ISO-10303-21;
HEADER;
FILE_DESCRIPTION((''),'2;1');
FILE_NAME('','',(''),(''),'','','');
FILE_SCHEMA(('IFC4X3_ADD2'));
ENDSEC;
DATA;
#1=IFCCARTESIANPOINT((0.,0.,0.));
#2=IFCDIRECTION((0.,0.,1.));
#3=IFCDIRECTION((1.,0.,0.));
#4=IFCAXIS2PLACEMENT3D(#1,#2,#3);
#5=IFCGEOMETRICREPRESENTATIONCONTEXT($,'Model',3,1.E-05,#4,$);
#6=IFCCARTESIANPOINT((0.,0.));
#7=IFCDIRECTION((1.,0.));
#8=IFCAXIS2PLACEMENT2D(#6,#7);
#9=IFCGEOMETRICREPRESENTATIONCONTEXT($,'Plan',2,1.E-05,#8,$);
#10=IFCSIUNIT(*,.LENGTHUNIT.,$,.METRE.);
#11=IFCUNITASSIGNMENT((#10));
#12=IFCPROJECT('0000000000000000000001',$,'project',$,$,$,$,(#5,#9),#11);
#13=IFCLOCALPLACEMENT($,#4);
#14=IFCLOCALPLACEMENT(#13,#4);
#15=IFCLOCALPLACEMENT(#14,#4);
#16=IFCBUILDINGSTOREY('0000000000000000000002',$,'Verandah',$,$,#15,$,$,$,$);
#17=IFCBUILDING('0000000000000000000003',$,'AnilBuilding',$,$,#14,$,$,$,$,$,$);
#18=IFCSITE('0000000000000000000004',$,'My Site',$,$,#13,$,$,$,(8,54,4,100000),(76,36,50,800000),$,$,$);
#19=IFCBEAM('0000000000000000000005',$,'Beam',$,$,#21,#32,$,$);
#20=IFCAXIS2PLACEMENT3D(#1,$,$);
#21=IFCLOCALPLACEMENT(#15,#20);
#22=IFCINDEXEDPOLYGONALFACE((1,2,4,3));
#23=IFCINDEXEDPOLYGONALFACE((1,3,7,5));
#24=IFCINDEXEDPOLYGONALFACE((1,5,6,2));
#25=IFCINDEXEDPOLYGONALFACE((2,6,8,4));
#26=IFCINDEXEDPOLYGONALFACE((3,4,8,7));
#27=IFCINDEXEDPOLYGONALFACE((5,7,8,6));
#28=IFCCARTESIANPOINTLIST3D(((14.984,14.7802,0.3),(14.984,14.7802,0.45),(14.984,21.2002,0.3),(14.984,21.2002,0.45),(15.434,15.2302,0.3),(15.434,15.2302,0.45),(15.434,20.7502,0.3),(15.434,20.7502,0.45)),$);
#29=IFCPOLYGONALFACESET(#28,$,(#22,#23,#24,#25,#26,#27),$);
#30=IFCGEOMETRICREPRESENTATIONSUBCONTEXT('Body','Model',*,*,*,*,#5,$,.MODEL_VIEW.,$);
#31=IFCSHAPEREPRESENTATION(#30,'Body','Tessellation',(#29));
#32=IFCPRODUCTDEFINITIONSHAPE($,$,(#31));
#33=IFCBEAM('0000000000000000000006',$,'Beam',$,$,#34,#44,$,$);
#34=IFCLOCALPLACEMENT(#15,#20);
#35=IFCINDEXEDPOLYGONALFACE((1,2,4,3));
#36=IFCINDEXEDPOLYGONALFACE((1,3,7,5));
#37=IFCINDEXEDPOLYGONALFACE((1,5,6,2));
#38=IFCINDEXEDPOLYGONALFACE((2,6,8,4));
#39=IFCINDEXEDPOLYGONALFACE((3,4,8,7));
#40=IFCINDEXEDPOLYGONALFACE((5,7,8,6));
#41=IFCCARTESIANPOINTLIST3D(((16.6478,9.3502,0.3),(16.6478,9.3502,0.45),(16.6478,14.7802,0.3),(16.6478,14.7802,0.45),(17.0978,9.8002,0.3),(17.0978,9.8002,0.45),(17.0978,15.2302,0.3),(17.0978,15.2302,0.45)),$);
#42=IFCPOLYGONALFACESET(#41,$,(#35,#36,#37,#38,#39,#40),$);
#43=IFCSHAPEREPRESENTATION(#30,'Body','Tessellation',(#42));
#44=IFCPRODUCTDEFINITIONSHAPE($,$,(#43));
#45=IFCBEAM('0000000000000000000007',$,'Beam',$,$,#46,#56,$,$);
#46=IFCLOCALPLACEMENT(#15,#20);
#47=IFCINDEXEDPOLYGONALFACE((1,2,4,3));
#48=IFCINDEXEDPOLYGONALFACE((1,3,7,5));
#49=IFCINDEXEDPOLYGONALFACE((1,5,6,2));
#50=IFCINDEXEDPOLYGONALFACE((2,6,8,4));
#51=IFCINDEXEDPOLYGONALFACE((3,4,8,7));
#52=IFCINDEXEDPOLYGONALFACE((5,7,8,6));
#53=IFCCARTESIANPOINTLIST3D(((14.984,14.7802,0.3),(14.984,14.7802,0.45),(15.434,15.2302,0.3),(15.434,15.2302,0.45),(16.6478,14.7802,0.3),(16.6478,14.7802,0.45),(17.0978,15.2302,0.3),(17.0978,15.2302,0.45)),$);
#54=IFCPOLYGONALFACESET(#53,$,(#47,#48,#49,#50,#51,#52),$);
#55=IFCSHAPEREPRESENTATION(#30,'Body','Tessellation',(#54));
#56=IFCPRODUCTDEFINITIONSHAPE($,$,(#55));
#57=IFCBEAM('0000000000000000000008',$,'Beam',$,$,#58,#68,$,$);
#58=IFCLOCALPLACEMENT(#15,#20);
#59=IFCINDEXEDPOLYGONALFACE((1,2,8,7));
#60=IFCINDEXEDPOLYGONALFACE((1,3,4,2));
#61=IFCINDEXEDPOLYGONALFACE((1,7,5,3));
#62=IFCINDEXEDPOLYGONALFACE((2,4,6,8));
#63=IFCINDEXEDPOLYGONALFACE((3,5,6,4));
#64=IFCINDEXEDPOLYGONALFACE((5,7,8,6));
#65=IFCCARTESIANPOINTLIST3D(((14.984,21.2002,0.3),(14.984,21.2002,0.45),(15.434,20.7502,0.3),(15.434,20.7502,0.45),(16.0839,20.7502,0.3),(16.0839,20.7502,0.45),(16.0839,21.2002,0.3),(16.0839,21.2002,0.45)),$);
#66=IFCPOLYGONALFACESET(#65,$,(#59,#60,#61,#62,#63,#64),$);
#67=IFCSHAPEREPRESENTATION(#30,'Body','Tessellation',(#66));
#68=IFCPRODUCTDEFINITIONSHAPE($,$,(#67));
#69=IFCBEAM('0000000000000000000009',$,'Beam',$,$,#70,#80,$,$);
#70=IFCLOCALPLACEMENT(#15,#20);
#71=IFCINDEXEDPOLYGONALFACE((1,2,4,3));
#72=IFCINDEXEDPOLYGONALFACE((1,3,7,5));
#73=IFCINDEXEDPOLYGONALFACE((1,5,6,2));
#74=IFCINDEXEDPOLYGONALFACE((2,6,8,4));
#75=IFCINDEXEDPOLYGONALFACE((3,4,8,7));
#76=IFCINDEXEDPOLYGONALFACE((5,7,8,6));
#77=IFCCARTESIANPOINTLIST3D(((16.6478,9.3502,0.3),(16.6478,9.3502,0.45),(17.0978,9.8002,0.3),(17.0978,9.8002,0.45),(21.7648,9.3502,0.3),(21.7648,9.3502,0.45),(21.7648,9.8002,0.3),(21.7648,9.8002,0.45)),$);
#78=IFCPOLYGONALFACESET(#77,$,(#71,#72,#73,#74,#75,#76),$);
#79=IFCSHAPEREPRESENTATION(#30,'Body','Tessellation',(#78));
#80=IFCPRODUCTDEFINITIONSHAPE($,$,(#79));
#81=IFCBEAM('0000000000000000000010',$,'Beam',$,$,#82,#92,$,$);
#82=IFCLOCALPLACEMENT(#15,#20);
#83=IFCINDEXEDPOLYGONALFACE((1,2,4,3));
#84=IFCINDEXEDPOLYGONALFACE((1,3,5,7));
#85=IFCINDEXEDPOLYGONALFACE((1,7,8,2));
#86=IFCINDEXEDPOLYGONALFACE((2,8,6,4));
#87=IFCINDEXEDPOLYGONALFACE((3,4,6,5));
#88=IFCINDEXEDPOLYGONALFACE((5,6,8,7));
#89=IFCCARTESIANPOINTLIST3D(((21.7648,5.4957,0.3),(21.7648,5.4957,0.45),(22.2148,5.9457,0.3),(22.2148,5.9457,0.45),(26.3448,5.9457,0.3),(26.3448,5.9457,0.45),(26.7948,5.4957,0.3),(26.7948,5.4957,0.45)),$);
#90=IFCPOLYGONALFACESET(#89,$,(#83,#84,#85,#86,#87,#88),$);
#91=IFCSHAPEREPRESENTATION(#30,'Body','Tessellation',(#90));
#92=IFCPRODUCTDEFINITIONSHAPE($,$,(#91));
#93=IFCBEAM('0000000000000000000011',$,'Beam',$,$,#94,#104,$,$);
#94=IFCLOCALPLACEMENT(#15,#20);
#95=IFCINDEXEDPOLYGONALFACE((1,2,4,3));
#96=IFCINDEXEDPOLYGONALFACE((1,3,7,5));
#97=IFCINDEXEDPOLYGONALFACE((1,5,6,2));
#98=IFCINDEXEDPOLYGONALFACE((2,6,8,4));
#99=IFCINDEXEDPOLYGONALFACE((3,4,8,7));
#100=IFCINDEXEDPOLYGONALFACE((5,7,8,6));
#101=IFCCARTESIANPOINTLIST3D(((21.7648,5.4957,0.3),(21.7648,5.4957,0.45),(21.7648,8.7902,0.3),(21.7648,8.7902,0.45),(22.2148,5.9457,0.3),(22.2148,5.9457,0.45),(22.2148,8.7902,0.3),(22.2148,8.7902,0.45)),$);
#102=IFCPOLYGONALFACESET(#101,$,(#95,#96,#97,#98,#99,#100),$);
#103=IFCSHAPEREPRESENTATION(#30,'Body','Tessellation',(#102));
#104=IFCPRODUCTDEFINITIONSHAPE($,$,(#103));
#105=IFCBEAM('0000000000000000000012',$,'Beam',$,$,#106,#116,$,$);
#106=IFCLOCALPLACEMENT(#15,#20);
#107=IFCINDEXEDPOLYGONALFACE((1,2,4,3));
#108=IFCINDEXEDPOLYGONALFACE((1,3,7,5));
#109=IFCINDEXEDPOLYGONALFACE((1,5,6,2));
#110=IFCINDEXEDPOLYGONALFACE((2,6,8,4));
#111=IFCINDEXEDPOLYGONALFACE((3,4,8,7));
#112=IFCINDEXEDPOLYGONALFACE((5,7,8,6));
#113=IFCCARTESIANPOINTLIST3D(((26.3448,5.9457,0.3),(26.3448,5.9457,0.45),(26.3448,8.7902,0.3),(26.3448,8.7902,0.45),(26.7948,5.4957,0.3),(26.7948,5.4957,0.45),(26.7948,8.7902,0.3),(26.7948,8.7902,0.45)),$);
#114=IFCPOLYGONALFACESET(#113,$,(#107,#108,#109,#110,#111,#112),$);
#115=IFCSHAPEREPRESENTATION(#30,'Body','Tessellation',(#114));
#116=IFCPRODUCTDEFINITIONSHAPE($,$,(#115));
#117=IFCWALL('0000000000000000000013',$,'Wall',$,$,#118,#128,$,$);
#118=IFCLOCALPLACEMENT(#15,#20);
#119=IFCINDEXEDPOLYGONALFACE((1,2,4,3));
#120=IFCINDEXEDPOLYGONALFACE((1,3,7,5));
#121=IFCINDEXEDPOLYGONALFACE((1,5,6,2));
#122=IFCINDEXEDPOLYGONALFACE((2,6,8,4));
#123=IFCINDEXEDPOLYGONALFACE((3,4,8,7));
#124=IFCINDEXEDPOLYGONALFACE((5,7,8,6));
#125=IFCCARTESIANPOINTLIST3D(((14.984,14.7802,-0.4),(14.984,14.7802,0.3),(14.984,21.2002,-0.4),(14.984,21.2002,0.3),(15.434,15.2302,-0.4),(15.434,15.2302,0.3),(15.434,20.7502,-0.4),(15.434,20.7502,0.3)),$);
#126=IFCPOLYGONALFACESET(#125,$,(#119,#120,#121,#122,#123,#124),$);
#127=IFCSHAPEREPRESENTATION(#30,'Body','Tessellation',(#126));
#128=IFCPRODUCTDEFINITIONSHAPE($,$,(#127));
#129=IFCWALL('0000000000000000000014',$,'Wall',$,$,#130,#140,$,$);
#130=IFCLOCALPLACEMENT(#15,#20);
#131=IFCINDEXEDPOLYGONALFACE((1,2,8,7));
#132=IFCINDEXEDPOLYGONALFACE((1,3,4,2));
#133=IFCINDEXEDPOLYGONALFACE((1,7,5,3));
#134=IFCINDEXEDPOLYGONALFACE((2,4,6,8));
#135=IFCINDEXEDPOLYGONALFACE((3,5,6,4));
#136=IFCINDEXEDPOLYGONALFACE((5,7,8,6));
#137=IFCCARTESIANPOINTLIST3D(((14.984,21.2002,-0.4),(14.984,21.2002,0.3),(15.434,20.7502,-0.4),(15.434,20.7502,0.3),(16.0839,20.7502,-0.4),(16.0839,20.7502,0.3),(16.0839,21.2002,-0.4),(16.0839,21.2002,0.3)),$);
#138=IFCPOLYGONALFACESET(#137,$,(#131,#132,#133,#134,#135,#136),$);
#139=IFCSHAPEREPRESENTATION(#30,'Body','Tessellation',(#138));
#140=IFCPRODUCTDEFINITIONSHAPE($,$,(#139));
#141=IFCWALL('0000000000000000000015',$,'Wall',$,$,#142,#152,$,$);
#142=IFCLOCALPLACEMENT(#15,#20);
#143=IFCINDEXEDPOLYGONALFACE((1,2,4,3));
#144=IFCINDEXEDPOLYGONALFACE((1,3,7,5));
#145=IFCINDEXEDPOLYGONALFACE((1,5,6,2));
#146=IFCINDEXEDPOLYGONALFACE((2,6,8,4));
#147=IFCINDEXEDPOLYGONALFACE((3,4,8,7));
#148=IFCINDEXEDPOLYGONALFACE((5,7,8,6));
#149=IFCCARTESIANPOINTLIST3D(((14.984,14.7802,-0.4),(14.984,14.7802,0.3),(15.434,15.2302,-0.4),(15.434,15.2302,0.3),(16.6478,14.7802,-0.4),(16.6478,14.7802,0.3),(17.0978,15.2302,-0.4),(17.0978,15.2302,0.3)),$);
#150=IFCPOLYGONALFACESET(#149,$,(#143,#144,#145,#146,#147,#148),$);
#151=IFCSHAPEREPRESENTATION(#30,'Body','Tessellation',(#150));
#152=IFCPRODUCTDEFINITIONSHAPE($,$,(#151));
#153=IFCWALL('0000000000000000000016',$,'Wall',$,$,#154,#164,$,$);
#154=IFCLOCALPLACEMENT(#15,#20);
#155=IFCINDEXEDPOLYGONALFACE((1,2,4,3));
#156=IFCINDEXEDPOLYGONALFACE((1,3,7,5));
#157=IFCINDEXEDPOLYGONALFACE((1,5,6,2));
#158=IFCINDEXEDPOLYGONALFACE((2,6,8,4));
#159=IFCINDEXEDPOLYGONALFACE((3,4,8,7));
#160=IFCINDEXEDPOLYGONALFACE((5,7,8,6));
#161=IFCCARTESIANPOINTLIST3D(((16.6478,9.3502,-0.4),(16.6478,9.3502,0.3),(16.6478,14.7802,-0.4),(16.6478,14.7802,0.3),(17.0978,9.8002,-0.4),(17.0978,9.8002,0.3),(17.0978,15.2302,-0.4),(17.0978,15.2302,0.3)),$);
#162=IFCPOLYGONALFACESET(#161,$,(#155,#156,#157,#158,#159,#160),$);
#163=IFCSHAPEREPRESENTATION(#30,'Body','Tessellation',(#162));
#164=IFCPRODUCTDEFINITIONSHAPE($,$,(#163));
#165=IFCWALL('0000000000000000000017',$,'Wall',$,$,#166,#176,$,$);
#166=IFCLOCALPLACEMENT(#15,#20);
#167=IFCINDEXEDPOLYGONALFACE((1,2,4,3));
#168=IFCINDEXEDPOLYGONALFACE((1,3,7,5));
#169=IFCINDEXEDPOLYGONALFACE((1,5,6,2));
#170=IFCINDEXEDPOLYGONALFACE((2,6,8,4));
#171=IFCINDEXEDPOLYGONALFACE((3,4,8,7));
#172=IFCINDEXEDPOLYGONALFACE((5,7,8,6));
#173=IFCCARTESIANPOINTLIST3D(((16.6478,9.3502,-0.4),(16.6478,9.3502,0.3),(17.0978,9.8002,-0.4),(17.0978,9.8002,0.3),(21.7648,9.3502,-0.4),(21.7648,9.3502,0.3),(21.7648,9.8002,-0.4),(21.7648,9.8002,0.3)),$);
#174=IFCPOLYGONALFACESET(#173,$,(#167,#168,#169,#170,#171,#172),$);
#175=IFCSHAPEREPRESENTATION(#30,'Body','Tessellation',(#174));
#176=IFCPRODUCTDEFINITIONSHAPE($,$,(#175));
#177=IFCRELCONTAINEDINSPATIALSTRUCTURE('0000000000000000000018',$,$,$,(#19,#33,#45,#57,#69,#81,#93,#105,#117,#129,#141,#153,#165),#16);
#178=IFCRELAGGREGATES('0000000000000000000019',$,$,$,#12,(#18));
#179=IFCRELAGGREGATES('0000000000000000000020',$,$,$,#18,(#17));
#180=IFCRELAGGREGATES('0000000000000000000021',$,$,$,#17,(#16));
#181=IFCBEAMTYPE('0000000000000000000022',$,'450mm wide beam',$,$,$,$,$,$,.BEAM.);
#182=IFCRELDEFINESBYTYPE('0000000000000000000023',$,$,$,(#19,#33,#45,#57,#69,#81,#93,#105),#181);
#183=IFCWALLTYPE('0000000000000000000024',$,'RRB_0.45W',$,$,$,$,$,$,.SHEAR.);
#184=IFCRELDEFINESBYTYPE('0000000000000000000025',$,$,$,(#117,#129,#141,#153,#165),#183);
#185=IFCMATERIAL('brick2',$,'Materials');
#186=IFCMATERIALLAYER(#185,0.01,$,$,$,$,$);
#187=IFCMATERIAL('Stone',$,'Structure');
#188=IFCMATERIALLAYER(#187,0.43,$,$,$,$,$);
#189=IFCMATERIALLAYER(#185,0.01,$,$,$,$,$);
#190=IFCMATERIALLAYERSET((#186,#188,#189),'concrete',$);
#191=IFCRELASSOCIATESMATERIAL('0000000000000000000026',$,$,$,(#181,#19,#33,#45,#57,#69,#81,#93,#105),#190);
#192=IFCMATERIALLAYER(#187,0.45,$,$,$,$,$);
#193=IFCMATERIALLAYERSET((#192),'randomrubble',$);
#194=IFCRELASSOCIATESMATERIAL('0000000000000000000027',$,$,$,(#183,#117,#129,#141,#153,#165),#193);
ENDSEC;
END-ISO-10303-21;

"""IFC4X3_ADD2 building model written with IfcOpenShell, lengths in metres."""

from ifc_helpers import new_model, si_unit, frame, origin_with_axes, origin_2d_with_axis, place, context, subcontext, project, spatial, line, indexed_curve, outline, extrude, material, layer, layer_set, layer_usage, type_object, element, save


model = new_model("IFC4X3_ADD2")

# Units and contexts
model_context = context("Model", 3, precision=1e-05, world=origin_with_axes())
plan_context = context("Plan", 2, precision=1e-05, world=origin_2d_with_axis())
body_context = subcontext(model_context, "Body", "Model", "MODEL_VIEW")
ifc_project = project(units=[si_unit("LENGTHUNIT", "METRE")], contexts=[model_context, plan_context])

# Site, building, storey
site_placement = place(None, origin_with_axes())
site = spatial("IfcSite", under=ifc_project, at=site_placement, Name="My Site", RefLatitude=(8, 54, 4, 100000), RefLongitude=(76, 36, 50, 800000))
building_placement = place(site_placement, origin_with_axes())
building = spatial("IfcBuilding", under=site, at=building_placement, Name="AnilBuilding")
storey_placement = place(building_placement, origin_with_axes())
storey = spatial("IfcBuildingStorey", under=building, at=storey_placement, Name="Verandah")

# Beams
ifc_material_1 = material(Name="brick2", Category="Materials")
ifc_layer_1 = layer(ifc_material_1, 0.01)
ifc_material_2 = material(Name="Stone", Category="Structure")
ifc_layer_2 = layer(ifc_material_2, 0.43)
ifc_layer_3 = layer(ifc_material_1, 0.01)
ifc_layer_set_1 = layer_set([ifc_layer_1, ifc_layer_2, ifc_layer_3], Name="concrete")
ifc_layer_usage_1 = layer_usage(ifc_layer_set_1, "AXIS2", "POSITIVE", 0.0)
beam_type = type_object("IfcBeamType", Name="450mm wide beam", PredefinedType="BEAM", material=ifc_layer_set_1)
beam_1_placement = place(storey_placement, frame((14.984, 21.2002, 0.3), z_axis=(0.0, 0.0, 1.0), x_axis=(0.0, -1.0, 0.0)))
element("IfcBeam", 1, at=beam_1_placement, inside=storey, type_object=beam_type, material=ifc_layer_usage_1, Name="Beam", context=body_context, shape_type="SweptSolid", body=[
    extrude(outline(indexed_curve([(0.0, 0.0), (0.45, 0.45), (5.97, 0.45), (6.42, 0.0)], segments=[line(1, 2, 3, 4, 1)])), origin_with_axes(), (0.0, 0.0, 1.0), 0.15),
])
ifc_layer_usage_2 = layer_usage(ifc_layer_set_1, "AXIS2", "POSITIVE", 0.0)
beam_2_placement = place(storey_placement, frame((16.6478, 15.2302, 0.3), z_axis=(0.0, 0.0, 1.0), x_axis=(0.0, -1.0, 0.0)))
element("IfcBeam", 2, at=beam_2_placement, inside=storey, type_object=beam_type, material=ifc_layer_usage_2, Name="Beam", context=body_context, shape_type="SweptSolid", body=[
    extrude(outline(indexed_curve([(0.45, 0.0), (0.0, 0.45), (5.43, 0.45), (5.88, 0.0)], segments=[line(1, 2, 3, 4, 1)])), origin_with_axes(), (0.0, 0.0, 1.0), 0.15),
])
ifc_layer_usage_3 = layer_usage(ifc_layer_set_1, "AXIS2", "NEGATIVE", 0.0)
beam_3_placement = place(storey_placement, frame((14.984, 15.2302, 0.3), z_axis=(0.0, 0.0, 1.0), x_axis=(1.0, 0.0, 0.0)))
element("IfcBeam", 3, at=beam_3_placement, inside=storey, type_object=beam_type, material=ifc_layer_usage_3, Name="Beam", context=body_context, shape_type="SweptSolid", body=[
    extrude(outline(indexed_curve([(0.0, -0.45), (0.45, 0.0), (2.1138, 0.0), (1.6638, -0.45)], segments=[line(1, 2, 3, 4, 1)])), origin_with_axes(), (0.0, 0.0, 1.0), 0.15),
])
ifc_layer_usage_4 = layer_usage(ifc_layer_set_1, "AXIS2", "NEGATIVE", 0.0)
beam_4_placement = place(storey_placement, frame((14.984, 21.2002, 0.3), z_axis=(0.0, 0.0, 1.0), x_axis=(1.0, 0.0, 0.0)))
element("IfcBeam", 4, at=beam_4_placement, inside=storey, type_object=beam_type, material=ifc_layer_usage_4, Name="Beam", context=body_context, shape_type="SweptSolid", body=[
    extrude(outline(indexed_curve([(0.45, -0.45), (0.0, 0.0), (1.1, 0.0), (1.1, -0.45)], segments=[line(1, 2, 3, 4, 1)])), origin_with_axes(), (0.0, 0.0, 1.0), 0.15),
])
ifc_layer_usage_5 = layer_usage(ifc_layer_set_1, "AXIS2", "NEGATIVE", 0.0)
beam_5_placement = place(storey_placement, frame((16.6478, 9.8002, 0.3), z_axis=(0.0, 0.0, 1.0), x_axis=(1.0, 0.0, 0.0)))
element("IfcBeam", 5, at=beam_5_placement, inside=storey, type_object=beam_type, material=ifc_layer_usage_5, Name="Beam", context=body_context, shape_type="SweptSolid", body=[
    extrude(outline(indexed_curve([(0.0, -0.45), (0.45, 0.0), (5.117, 0.0), (5.117, -0.45)], segments=[line(1, 2, 3, 4, 1)])), origin_with_axes(), (0.0, 0.0, 1.0), 0.15),
])
ifc_layer_usage_6 = layer_usage(ifc_layer_set_1, "AXIS2", "NEGATIVE", 0.0)
beam_6_placement = place(storey_placement, frame((21.7648, 5.9457, 0.3), z_axis=(0.0, 0.0, 1.0), x_axis=(1.0, 0.0, 0.0)))
element("IfcBeam", 6, at=beam_6_placement, inside=storey, type_object=beam_type, material=ifc_layer_usage_6, Name="Beam", context=body_context, shape_type="SweptSolid", body=[
    extrude(outline(indexed_curve([(0.0, -0.45), (0.45, 0.0), (4.58, 0.0), (5.03, -0.45)], segments=[line(1, 2, 3, 4, 1)])), origin_with_axes(), (0.0, 0.0, 1.0), 0.15),
])
ifc_layer_usage_7 = layer_usage(ifc_layer_set_1, "AXIS2", "POSITIVE", 0.0)
beam_7_placement = place(storey_placement, frame((21.7648, 8.7902, 0.3), z_axis=(0.0, 0.0, 1.0), x_axis=(0.0, -1.0, 0.0)))
element("IfcBeam", 7, at=beam_7_placement, inside=storey, type_object=beam_type, material=ifc_layer_usage_7, Name="Beam", context=body_context, shape_type="SweptSolid", body=[
    extrude(outline(indexed_curve([(0.0, 0.0), (0.0, 0.45), (2.8445, 0.45), (3.2945, 0.0)], segments=[line(1, 2, 3, 4, 1)])), origin_with_axes(), (0.0, 0.0, 1.0), 0.15),
])
ifc_layer_usage_8 = layer_usage(ifc_layer_set_1, "AXIS2", "POSITIVE", 0.0)
beam_8_placement = place(storey_placement, frame((26.3448, 8.7902, 0.3), z_axis=(0.0, 0.0, 1.0), x_axis=(0.0, -1.0, 0.0)))
element("IfcBeam", 8, at=beam_8_placement, inside=storey, type_object=beam_type, material=ifc_layer_usage_8, Name="Beam", context=body_context, shape_type="SweptSolid", body=[
    extrude(outline(indexed_curve([(0.0, 0.0), (0.0, 0.45), (3.2945, 0.45), (2.8445, 0.0)], segments=[line(1, 2, 3, 4, 1)])), origin_with_axes(), (0.0, 0.0, 1.0), 0.15),
])

# Walls
ifc_layer_4 = layer(ifc_material_2, 0.45)
ifc_layer_set_2 = layer_set([ifc_layer_4], Name="randomrubble")
ifc_layer_usage_9 = layer_usage(ifc_layer_set_2, "AXIS2", "POSITIVE", 0.0)
wall_type_1 = type_object("IfcWallType", Name="RRB_0.45W", PredefinedType="SHEAR", material=ifc_layer_set_2)
wall_1_placement = place(storey_placement, frame((15.434, 14.7802, -0.4), z_axis=(0.0, 0.0, 1.0), x_axis=(0.000001, 1.0, 0.0)))
element("IfcWall", 9, at=wall_1_placement, inside=storey, type_object=wall_type_1, material=ifc_layer_usage_9, Name="Wall", context=body_context, shape_type="SweptSolid", body=[
    extrude(outline(indexed_curve([(0.45, 0.0), (0.0, 0.45), (6.42, 0.45), (5.97, 0.0)], segments=[line(1, 2, 3, 4, 1)])), origin_with_axes(), (0.0, 0.0, 1.0), 0.7),
])
ifc_layer_usage_10 = layer_usage(ifc_layer_set_2, "AXIS2", "POSITIVE", 0.0)
wall_2_placement = place(storey_placement, frame((15.434, 20.7502, -0.4), z_axis=(0.0, 0.0, 1.0), x_axis=(1.0, 0.0, 0.0)))
element("IfcWall", 10, at=wall_2_placement, inside=storey, type_object=wall_type_1, material=ifc_layer_usage_10, Name="Wall", context=body_context, shape_type="SweptSolid", body=[
    extrude(outline(indexed_curve([(0.0, 0.0), (-0.45, 0.45), (0.6499, 0.45), (0.6499, 0.0)], segments=[line(1, 2, 3, 4, 1)])), origin_with_axes(), (0.0, 0.0, 1.0), 0.7),
])
ifc_layer_usage_11 = layer_usage(ifc_layer_set_2, "AXIS2", "POSITIVE", 0.0)
wall_3_placement = place(storey_placement, frame((15.434, 14.7802, -0.4), z_axis=(0.0, 0.0, 1.0), x_axis=(1.0, 0.0, 0.0)))
element("IfcWall", 11, at=wall_3_placement, inside=storey, type_object=wall_type_1, material=ifc_layer_usage_11, Name="Wall", context=body_context, shape_type="SweptSolid", body=[
    extrude(outline(indexed_curve([(-0.45, 0.0), (0.0, 0.45), (1.6638, 0.45), (1.2138, 0.0)], segments=[line(1, 2, 3, 4, 1)])), origin_with_axes(), (0.0, 0.0, 1.0), 0.7),
])
ifc_layer_usage_12 = layer_usage(ifc_layer_set_2, "AXIS2", "POSITIVE", 0.0)
wall_4_placement = place(storey_placement, frame((17.0978, 9.3502, -0.4), z_axis=(0.0, 0.0, 1.0), x_axis=(0.000001, 1.0, 0.0)))
element("IfcWall", 12, at=wall_4_placement, inside=storey, type_object=wall_type_1, material=ifc_layer_usage_12, Name="Wall", context=body_context, shape_type="SweptSolid", body=[
    extrude(outline(indexed_curve([(0.45, 0.0), (0.0, 0.45), (5.43, 0.45), (5.88, 0.0)], segments=[line(1, 2, 3, 4, 1)])), origin_with_axes(), (0.0, 0.0, 1.0), 0.7),
])
ifc_layer_usage_13 = layer_usage(ifc_layer_set_2, "AXIS2", "POSITIVE", 0.0)
wall_5_placement = place(storey_placement, frame((17.0978, 9.3502, -0.4), z_axis=(0.0, 0.0, 1.0), x_axis=(1.0, 0.0, 0.0)))
element("IfcWall", 13, at=wall_5_placement, inside=storey, type_object=wall_type_1, material=ifc_layer_usage_13, Name="Wall", context=body_context, shape_type="SweptSolid", body=[
    extrude(outline(indexed_curve([(-0.45, 0.0), (0.0, 0.45), (4.667, 0.45), (4.667, 0.0)], segments=[line(1, 2, 3, 4, 1)])), origin_with_axes(), (0.0, 0.0, 1.0), 0.7),
])

save(model, "model.ifc")
